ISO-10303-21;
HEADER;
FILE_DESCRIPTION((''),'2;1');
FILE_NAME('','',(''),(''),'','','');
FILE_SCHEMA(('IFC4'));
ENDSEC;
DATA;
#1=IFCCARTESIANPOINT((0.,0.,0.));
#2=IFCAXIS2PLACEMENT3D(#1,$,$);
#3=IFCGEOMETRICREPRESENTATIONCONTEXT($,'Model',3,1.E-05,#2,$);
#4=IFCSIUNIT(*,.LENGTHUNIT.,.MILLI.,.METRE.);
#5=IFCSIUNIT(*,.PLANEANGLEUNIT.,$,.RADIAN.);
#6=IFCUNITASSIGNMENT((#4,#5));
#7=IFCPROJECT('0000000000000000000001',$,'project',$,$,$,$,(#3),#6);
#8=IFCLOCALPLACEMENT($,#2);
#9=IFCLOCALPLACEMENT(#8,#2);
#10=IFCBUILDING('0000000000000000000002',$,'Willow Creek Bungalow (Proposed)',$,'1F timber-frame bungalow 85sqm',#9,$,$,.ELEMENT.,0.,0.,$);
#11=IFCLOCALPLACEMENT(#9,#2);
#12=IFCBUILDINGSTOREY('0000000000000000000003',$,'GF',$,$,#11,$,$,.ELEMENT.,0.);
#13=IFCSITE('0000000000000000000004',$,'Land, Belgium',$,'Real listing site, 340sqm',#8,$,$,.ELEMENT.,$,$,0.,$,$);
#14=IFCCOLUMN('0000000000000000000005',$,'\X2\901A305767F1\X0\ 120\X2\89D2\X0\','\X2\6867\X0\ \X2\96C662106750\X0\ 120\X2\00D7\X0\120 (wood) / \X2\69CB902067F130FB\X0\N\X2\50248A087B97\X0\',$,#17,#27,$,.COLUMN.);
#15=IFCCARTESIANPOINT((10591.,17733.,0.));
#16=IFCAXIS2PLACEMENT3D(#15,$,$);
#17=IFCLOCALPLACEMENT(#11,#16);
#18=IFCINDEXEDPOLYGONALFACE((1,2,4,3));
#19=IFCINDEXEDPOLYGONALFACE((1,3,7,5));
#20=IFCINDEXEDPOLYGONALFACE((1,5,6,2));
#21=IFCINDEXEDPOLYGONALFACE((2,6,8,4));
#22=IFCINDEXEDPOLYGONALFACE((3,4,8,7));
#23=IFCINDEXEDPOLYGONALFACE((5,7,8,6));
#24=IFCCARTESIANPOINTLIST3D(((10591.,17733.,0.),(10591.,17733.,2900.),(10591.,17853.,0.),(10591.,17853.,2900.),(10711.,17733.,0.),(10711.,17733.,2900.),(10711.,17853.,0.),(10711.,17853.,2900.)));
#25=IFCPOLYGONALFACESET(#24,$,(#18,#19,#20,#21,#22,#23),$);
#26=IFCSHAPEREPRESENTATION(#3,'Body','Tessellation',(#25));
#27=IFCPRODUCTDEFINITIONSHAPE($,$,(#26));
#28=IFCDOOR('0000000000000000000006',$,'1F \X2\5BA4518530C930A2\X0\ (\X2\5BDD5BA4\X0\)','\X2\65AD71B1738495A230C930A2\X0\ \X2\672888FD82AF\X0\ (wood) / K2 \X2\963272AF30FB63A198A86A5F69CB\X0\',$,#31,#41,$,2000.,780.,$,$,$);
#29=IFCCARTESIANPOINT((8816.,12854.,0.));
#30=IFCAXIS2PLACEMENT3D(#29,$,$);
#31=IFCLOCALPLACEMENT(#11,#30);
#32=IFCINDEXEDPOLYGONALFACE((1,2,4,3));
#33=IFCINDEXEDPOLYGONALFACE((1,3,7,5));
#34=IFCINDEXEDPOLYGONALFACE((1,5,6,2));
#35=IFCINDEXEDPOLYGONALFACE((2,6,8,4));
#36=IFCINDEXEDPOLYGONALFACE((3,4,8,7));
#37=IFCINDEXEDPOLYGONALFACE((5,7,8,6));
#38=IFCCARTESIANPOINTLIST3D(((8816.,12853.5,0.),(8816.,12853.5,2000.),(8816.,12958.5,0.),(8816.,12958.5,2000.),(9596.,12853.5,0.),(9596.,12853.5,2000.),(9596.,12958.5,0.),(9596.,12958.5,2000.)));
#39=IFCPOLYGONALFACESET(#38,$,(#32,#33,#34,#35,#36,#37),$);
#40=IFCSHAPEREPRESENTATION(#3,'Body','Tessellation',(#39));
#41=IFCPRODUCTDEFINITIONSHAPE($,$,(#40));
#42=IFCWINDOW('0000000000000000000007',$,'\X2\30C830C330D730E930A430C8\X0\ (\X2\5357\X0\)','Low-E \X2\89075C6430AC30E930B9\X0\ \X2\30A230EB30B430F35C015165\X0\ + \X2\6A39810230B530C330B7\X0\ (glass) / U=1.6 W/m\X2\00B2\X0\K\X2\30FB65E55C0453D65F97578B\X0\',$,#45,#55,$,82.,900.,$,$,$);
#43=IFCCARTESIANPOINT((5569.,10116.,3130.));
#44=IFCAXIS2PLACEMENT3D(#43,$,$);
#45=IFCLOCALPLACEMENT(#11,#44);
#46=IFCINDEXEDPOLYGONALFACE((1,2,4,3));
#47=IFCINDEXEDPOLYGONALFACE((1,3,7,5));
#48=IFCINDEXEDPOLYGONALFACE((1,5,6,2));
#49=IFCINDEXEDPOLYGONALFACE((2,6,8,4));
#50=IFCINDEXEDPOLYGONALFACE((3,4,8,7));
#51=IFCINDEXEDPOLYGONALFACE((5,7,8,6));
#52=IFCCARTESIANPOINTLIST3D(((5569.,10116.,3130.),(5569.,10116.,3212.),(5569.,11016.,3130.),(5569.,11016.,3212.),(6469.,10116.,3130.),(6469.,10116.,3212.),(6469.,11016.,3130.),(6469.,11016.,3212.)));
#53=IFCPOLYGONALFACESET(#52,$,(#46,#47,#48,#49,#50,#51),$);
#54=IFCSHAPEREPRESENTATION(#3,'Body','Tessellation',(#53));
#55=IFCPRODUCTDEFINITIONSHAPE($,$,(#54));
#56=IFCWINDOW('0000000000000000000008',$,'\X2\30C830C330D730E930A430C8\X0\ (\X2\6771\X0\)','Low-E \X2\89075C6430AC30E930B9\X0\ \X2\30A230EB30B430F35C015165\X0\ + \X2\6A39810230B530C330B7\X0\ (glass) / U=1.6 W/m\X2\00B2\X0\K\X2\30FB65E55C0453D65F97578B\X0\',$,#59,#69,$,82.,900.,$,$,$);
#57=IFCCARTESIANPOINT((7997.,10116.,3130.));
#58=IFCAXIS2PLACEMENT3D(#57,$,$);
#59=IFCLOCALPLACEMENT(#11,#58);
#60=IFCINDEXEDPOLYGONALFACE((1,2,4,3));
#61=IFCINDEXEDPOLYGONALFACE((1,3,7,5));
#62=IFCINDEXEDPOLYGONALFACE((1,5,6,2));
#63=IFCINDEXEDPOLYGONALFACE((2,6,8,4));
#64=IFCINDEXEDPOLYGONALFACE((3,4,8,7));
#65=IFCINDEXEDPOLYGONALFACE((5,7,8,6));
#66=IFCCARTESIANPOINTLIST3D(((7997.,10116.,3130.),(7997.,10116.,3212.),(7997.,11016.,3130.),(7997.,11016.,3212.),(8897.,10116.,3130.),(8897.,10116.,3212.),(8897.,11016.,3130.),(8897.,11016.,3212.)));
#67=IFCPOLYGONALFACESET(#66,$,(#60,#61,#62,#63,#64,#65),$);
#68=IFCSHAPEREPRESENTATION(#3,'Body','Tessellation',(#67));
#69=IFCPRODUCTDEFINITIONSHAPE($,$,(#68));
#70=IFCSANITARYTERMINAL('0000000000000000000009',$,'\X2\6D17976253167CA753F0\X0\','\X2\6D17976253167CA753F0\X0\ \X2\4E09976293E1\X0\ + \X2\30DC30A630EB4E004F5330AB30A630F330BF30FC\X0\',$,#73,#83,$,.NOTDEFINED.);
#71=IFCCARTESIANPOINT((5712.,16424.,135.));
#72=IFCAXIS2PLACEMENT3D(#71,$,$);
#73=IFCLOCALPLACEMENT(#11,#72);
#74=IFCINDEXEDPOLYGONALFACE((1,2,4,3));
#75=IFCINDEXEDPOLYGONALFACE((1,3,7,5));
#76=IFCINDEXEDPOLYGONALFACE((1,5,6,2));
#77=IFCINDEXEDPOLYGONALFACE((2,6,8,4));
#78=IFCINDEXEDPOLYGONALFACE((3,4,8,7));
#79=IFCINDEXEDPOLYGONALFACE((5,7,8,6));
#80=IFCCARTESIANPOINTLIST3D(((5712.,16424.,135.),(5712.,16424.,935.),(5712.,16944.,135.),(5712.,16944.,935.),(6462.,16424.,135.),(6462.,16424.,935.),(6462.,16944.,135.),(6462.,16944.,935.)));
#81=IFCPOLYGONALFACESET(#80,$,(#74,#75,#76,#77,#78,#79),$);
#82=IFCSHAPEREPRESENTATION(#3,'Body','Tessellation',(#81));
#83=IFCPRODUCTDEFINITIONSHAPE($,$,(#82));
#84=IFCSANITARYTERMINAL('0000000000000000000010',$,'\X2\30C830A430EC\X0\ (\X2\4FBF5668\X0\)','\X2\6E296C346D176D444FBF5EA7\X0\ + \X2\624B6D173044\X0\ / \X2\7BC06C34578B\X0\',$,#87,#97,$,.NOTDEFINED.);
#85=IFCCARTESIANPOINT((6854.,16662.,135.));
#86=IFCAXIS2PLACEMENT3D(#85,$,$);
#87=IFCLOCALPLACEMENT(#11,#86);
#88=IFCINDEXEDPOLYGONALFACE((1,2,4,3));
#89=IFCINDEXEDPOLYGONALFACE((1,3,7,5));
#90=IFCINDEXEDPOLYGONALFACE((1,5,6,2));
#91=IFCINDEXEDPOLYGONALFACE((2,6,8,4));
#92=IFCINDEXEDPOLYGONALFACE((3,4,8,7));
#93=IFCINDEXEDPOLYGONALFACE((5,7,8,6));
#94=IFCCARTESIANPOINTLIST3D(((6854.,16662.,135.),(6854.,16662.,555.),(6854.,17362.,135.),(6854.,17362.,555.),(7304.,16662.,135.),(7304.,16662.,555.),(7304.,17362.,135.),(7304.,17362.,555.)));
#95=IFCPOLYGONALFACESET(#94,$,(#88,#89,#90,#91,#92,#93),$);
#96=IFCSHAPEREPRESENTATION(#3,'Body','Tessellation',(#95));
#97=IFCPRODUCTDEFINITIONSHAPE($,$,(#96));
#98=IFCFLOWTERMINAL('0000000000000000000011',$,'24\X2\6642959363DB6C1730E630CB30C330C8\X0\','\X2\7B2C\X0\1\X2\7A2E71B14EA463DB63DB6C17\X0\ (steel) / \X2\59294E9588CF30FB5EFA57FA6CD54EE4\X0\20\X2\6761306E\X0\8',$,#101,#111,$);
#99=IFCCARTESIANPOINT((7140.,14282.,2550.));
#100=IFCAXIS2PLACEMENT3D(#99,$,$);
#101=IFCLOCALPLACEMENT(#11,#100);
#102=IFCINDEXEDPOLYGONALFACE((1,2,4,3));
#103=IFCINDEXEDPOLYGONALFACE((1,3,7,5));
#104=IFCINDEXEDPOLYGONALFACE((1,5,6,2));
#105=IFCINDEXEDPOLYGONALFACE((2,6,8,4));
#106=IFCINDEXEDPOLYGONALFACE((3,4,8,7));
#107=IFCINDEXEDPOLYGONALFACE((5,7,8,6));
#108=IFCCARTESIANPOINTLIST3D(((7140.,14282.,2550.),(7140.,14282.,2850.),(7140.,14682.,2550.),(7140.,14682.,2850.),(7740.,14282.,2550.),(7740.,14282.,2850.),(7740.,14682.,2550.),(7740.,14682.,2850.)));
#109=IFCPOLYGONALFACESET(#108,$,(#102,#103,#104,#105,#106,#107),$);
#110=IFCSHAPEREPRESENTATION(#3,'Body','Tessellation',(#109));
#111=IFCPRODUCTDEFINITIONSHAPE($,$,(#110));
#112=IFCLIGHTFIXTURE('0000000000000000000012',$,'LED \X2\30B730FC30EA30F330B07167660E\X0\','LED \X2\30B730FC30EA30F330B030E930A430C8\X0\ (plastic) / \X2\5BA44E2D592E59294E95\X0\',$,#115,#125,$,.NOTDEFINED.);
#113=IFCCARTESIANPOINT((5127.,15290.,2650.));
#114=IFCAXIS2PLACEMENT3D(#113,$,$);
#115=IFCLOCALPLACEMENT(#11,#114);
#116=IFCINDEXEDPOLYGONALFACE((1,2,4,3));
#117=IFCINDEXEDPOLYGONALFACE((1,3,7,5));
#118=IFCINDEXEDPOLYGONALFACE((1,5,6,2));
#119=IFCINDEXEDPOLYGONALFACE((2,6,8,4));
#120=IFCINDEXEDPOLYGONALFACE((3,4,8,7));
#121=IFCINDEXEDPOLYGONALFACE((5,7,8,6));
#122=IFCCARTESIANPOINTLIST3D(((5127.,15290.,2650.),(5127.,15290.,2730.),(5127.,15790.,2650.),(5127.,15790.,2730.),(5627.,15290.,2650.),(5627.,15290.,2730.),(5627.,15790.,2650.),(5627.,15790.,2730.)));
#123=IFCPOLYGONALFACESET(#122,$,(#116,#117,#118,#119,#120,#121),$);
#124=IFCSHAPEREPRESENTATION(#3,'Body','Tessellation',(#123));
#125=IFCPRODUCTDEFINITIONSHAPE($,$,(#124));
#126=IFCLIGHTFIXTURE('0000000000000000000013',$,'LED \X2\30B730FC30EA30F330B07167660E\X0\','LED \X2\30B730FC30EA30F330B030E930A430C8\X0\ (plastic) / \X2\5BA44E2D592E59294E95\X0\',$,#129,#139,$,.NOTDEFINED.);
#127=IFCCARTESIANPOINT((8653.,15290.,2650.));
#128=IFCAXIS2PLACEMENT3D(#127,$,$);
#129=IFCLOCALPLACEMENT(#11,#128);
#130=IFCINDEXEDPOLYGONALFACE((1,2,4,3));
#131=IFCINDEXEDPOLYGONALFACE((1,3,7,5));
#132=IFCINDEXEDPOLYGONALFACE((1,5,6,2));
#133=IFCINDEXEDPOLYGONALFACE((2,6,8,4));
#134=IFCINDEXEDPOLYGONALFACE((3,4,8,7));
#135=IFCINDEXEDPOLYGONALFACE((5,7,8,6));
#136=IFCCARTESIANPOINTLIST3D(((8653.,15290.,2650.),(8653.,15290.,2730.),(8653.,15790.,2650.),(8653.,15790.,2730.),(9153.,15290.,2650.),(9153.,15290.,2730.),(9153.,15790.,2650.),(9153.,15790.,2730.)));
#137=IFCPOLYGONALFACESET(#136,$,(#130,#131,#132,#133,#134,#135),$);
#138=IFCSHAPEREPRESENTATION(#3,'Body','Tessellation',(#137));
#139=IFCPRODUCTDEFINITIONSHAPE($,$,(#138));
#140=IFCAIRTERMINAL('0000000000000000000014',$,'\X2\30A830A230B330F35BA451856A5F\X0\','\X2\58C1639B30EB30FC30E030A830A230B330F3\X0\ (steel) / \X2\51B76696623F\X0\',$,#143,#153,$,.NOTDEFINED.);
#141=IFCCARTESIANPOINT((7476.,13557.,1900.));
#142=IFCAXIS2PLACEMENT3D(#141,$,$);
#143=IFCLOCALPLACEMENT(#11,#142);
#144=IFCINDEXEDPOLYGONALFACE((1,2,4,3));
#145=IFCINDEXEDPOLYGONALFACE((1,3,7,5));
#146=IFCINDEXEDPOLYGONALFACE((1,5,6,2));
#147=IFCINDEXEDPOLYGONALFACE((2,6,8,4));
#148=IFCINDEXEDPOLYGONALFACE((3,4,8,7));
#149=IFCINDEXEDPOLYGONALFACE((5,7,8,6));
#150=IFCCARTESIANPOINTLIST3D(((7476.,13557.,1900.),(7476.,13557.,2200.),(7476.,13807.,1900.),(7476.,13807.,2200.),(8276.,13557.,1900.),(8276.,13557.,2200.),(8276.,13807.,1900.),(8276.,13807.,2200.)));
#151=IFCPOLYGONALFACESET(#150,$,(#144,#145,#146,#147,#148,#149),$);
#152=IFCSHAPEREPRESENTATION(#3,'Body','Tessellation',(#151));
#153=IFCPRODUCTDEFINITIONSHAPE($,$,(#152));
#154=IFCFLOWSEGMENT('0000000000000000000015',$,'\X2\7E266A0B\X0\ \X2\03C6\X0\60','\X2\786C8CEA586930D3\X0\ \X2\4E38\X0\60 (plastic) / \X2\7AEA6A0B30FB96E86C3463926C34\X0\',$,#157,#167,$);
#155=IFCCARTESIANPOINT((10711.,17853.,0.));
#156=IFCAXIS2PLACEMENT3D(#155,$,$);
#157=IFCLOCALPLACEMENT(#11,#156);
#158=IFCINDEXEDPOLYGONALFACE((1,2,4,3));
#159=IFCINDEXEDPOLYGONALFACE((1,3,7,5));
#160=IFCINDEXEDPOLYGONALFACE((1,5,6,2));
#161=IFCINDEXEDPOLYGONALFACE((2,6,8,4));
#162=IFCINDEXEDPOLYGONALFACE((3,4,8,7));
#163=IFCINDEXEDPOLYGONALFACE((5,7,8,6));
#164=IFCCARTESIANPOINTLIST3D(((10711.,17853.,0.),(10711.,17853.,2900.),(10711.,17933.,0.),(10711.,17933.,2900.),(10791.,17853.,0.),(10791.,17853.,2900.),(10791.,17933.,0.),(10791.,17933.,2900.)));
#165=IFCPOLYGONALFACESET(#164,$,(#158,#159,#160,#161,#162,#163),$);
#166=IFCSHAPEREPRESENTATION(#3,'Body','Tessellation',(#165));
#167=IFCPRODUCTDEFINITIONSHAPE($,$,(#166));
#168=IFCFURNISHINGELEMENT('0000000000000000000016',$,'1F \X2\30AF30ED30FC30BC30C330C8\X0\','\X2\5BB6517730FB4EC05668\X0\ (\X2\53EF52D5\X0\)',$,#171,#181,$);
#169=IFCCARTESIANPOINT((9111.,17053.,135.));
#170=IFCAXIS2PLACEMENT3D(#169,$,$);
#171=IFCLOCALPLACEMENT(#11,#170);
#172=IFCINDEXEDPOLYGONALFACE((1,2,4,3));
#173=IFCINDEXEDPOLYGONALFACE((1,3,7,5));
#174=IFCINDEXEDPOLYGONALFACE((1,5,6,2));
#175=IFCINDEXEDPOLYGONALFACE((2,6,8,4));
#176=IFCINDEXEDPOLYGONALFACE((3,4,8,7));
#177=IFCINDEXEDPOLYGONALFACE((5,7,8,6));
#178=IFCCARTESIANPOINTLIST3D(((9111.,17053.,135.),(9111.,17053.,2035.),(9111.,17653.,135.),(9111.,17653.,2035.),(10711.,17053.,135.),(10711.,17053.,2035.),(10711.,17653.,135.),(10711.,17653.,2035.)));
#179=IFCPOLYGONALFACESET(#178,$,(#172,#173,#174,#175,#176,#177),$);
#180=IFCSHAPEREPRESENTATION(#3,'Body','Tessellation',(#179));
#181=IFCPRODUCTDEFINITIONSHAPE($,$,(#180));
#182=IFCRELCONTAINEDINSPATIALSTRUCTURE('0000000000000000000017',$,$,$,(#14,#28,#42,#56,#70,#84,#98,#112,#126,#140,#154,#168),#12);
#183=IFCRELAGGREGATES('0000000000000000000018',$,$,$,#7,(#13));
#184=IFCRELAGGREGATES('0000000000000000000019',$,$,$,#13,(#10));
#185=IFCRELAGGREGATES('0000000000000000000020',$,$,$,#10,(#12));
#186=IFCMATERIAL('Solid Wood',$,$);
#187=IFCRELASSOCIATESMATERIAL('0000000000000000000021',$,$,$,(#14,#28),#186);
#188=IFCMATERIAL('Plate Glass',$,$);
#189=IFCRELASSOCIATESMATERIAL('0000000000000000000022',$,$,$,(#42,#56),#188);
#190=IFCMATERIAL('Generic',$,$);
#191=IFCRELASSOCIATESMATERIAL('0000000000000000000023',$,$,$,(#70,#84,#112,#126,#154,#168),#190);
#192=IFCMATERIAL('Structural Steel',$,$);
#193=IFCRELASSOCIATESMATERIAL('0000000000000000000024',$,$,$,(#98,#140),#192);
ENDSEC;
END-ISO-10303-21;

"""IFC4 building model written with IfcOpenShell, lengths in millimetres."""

from ifc_helpers import new_model, si_unit, frame, frame_2d, origin, place, context, project, spatial, rectangle, extrude, material, element, save


model = new_model("IFC4")

# Units and contexts
model_context = context("Model", 3, precision=1e-05, world=origin())
ifc_project = project(units=[si_unit("LENGTHUNIT", "METRE", prefix="MILLI"), si_unit("PLANEANGLEUNIT", "RADIAN")], contexts=[model_context])

# Site, building, storey
site_placement = place(None, origin())
site = spatial("IfcSite", under=ifc_project, at=site_placement, Name="Land, Belgium", ObjectType="Real listing site, 340sqm", CompositionType="ELEMENT", RefElevation=0.0)
building_placement = place(site_placement, origin())
building = spatial("IfcBuilding", under=site, at=building_placement, Name="Willow Creek Bungalow (Proposed)", ObjectType="1F timber-frame bungalow 85sqm", CompositionType="ELEMENT", ElevationOfRefHeight=0.0, ElevationOfTerrain=0.0)
storey_placement = place(building_placement, origin())
storey = spatial("IfcBuildingStorey", under=building, at=storey_placement, Name="GF", CompositionType="ELEMENT", Elevation=0.0)

# Column
ifc_material_1 = material(Name="Solid Wood")
column_1_placement = place(storey_placement, frame((10591.0, 17733.0, 0.0)))
element("IfcColumn", 1, at=column_1_placement, inside=storey, material=ifc_material_1, Name="通し柱 120角", Description="桧 集成材 120×120 (wood) / 構造柱・N値計算", PredefinedType="COLUMN", context=model_context, shape_type="SweptSolid", body=[
    extrude(rectangle(XDim=120.0, YDim=120.0, at=frame_2d((60.0, 60.0))), frame((10591.0, 17733.0, 0.0)), (0.0, 0.0, 1.0), 2900.0),
])

# Door
door_placement = place(storey_placement, frame((8816.0, 12854.0, 0.0)))
element("IfcDoor", 2, at=door_placement, inside=storey, material=ifc_material_1, Name="1F 室内ドア (寝室)", Description="断熱玄関ドア 木製芯 (wood) / K2 防犯・採風機構", OverallHeight=2000.0, OverallWidth=780.0, context=model_context, shape_type="SweptSolid", body=[
    extrude(rectangle(XDim=780.0, YDim=105.0, at=frame_2d((390.0, 52.0))), frame((8816.0, 12854.0, 0.0)), (0.0, 0.0, 1.0), 2000.0),
])

# Windows
ifc_material_2 = material(Name="Plate Glass")
window_1_placement = place(storey_placement, frame((5569.0, 10116.0, 3130.0)))
element("IfcWindow", 3, at=window_1_placement, inside=storey, material=ifc_material_2, Name="トップライト (南)", Description="Low-E 複層ガラス アルゴン封入 + 樹脂サッシ (glass) / U=1.6 W/m²K・日射取得型", OverallHeight=82.0, OverallWidth=900.0, context=model_context, shape_type="SweptSolid", body=[
    extrude(rectangle(XDim=900.0, YDim=900.0, at=frame_2d((450.0, 450.0))), frame((5569.0, 10116.0, 3130.0)), (0.0, 0.0, 1.0), 82.0),
])
window_2_placement = place(storey_placement, frame((7997.0, 10116.0, 3130.0)))
element("IfcWindow", 4, at=window_2_placement, inside=storey, material=ifc_material_2, Name="トップライト (東)", Description="Low-E 複層ガラス アルゴン封入 + 樹脂サッシ (glass) / U=1.6 W/m²K・日射取得型", OverallHeight=82.0, OverallWidth=900.0, context=model_context, shape_type="SweptSolid", body=[
    extrude(rectangle(XDim=900.0, YDim=900.0, at=frame_2d((450.0, 450.0))), frame((7997.0, 10116.0, 3130.0)), (0.0, 0.0, 1.0), 82.0),
])

# Sanitary terminals
ifc_material_3 = material(Name="Generic")
sanitary_terminal_1_placement = place(storey_placement, frame((5712.0, 16424.0, 135.0)))
element("IfcSanitaryTerminal", 5, at=sanitary_terminal_1_placement, inside=storey, material=ifc_material_3, Name="洗面化粧台", Description="洗面化粧台 三面鏡 + ボウル一体カウンター", PredefinedType="NOTDEFINED", context=model_context, shape_type="SweptSolid", body=[
    extrude(rectangle(XDim=750.0, YDim=520.0, at=frame_2d((375.0, 260.0))), frame((5712.0, 16424.0, 135.0)), (0.0, 0.0, 1.0), 800.0),
])
sanitary_terminal_2_placement = place(storey_placement, frame((6854.0, 16662.0, 135.0)))
element("IfcSanitaryTerminal", 6, at=sanitary_terminal_2_placement, inside=storey, material=ifc_material_3, Name="トイレ (便器)", Description="温水洗浄便座 + 手洗い / 節水型", PredefinedType="NOTDEFINED", context=model_context, shape_type="SweptSolid", body=[
    extrude(rectangle(XDim=450.0, YDim=700.0, at=frame_2d((225.0, 350.0))), frame((6854.0, 16662.0, 135.0)), (0.0, 0.0, 1.0), 420.0),
])

# Flow terminal
ifc_material_4 = material(Name="Structural Steel")
flow_terminal_placement = place(storey_placement, frame((7140.0, 14282.0, 2550.0)))
element("IfcFlowTerminal", 7, at=flow_terminal_placement, inside=storey, material=ifc_material_4, Name="24時間換気ユニット", Description="第1種熱交換換気 (steel) / 天井裏・建基法令20条の8", context=model_context, shape_type="SweptSolid", body=[
    extrude(rectangle(XDim=600.0, YDim=400.0, at=frame_2d((300.0, 200.0))), frame((7140.0, 14282.0, 2550.0)), (0.0, 0.0, 1.0), 300.0),
])

# Light fixtures
light_fixture_1_placement = place(storey_placement, frame((5127.0, 15290.0, 2650.0)))
element("IfcLightFixture", 8, at=light_fixture_1_placement, inside=storey, material=ifc_material_3, Name="LED シーリング照明", Description="LED シーリングライト (plastic) / 室中央天井", PredefinedType="NOTDEFINED", context=model_context, shape_type="SweptSolid", body=[
    extrude(rectangle(XDim=500.0, YDim=500.0, at=frame_2d((250.0, 250.0))), frame((5127.0, 15290.0, 2650.0)), (0.0, 0.0, 1.0), 80.0),
])
light_fixture_2_placement = place(storey_placement, frame((8653.0, 15290.0, 2650.0)))
element("IfcLightFixture", 9, at=light_fixture_2_placement, inside=storey, material=ifc_material_3, Name="LED シーリング照明", Description="LED シーリングライト (plastic) / 室中央天井", PredefinedType="NOTDEFINED", context=model_context, shape_type="SweptSolid", body=[
    extrude(rectangle(XDim=500.0, YDim=500.0, at=frame_2d((250.0, 250.0))), frame((8653.0, 15290.0, 2650.0)), (0.0, 0.0, 1.0), 80.0),
])

# Air terminal
air_terminal_placement = place(storey_placement, frame((7476.0, 13557.0, 1900.0)))
element("IfcAirTerminal", 10, at=air_terminal_placement, inside=storey, material=ifc_material_4, Name="エアコン室内機", Description="壁掛ルームエアコン (steel) / 冷暖房", PredefinedType="NOTDEFINED", context=model_context, shape_type="SweptSolid", body=[
    extrude(rectangle(XDim=800.0, YDim=250.0, at=frame_2d((400.0, 125.0))), frame((7476.0, 13557.0, 1900.0)), (0.0, 0.0, 1.0), 300.0),
])

# Flow segment
flow_segment_placement = place(storey_placement, frame((10711.0, 17853.0, 0.0)))
element("IfcFlowSegment", 11, at=flow_segment_placement, inside=storey, material=ifc_material_3, Name="縦樋 φ60", Description="硬質塩ビ 丸60 (plastic) / 竪樋・雨水排水", context=model_context, shape_type="SweptSolid", body=[
    extrude(rectangle(XDim=80.0, YDim=80.0, at=frame_2d((40.0, 40.0))), frame((10711.0, 17853.0, 0.0)), (0.0, 0.0, 1.0), 2900.0),
])

# Furnishing element
furnishing_placement = place(storey_placement, frame((9111.0, 17053.0, 135.0)))
element("IfcFurnishingElement", 12, at=furnishing_placement, inside=storey, material=ifc_material_3, Name="1F クローゼット", Description="家具・什器 (可動)", context=model_context, shape_type="SweptSolid", body=[
    extrude(rectangle(XDim=1600.0, YDim=600.0, at=frame_2d((800.0, 300.0))), frame((9111.0, 17053.0, 135.0)), (0.0, 0.0, 1.0), 1900.0),
])

save(model, "model.ifc")
